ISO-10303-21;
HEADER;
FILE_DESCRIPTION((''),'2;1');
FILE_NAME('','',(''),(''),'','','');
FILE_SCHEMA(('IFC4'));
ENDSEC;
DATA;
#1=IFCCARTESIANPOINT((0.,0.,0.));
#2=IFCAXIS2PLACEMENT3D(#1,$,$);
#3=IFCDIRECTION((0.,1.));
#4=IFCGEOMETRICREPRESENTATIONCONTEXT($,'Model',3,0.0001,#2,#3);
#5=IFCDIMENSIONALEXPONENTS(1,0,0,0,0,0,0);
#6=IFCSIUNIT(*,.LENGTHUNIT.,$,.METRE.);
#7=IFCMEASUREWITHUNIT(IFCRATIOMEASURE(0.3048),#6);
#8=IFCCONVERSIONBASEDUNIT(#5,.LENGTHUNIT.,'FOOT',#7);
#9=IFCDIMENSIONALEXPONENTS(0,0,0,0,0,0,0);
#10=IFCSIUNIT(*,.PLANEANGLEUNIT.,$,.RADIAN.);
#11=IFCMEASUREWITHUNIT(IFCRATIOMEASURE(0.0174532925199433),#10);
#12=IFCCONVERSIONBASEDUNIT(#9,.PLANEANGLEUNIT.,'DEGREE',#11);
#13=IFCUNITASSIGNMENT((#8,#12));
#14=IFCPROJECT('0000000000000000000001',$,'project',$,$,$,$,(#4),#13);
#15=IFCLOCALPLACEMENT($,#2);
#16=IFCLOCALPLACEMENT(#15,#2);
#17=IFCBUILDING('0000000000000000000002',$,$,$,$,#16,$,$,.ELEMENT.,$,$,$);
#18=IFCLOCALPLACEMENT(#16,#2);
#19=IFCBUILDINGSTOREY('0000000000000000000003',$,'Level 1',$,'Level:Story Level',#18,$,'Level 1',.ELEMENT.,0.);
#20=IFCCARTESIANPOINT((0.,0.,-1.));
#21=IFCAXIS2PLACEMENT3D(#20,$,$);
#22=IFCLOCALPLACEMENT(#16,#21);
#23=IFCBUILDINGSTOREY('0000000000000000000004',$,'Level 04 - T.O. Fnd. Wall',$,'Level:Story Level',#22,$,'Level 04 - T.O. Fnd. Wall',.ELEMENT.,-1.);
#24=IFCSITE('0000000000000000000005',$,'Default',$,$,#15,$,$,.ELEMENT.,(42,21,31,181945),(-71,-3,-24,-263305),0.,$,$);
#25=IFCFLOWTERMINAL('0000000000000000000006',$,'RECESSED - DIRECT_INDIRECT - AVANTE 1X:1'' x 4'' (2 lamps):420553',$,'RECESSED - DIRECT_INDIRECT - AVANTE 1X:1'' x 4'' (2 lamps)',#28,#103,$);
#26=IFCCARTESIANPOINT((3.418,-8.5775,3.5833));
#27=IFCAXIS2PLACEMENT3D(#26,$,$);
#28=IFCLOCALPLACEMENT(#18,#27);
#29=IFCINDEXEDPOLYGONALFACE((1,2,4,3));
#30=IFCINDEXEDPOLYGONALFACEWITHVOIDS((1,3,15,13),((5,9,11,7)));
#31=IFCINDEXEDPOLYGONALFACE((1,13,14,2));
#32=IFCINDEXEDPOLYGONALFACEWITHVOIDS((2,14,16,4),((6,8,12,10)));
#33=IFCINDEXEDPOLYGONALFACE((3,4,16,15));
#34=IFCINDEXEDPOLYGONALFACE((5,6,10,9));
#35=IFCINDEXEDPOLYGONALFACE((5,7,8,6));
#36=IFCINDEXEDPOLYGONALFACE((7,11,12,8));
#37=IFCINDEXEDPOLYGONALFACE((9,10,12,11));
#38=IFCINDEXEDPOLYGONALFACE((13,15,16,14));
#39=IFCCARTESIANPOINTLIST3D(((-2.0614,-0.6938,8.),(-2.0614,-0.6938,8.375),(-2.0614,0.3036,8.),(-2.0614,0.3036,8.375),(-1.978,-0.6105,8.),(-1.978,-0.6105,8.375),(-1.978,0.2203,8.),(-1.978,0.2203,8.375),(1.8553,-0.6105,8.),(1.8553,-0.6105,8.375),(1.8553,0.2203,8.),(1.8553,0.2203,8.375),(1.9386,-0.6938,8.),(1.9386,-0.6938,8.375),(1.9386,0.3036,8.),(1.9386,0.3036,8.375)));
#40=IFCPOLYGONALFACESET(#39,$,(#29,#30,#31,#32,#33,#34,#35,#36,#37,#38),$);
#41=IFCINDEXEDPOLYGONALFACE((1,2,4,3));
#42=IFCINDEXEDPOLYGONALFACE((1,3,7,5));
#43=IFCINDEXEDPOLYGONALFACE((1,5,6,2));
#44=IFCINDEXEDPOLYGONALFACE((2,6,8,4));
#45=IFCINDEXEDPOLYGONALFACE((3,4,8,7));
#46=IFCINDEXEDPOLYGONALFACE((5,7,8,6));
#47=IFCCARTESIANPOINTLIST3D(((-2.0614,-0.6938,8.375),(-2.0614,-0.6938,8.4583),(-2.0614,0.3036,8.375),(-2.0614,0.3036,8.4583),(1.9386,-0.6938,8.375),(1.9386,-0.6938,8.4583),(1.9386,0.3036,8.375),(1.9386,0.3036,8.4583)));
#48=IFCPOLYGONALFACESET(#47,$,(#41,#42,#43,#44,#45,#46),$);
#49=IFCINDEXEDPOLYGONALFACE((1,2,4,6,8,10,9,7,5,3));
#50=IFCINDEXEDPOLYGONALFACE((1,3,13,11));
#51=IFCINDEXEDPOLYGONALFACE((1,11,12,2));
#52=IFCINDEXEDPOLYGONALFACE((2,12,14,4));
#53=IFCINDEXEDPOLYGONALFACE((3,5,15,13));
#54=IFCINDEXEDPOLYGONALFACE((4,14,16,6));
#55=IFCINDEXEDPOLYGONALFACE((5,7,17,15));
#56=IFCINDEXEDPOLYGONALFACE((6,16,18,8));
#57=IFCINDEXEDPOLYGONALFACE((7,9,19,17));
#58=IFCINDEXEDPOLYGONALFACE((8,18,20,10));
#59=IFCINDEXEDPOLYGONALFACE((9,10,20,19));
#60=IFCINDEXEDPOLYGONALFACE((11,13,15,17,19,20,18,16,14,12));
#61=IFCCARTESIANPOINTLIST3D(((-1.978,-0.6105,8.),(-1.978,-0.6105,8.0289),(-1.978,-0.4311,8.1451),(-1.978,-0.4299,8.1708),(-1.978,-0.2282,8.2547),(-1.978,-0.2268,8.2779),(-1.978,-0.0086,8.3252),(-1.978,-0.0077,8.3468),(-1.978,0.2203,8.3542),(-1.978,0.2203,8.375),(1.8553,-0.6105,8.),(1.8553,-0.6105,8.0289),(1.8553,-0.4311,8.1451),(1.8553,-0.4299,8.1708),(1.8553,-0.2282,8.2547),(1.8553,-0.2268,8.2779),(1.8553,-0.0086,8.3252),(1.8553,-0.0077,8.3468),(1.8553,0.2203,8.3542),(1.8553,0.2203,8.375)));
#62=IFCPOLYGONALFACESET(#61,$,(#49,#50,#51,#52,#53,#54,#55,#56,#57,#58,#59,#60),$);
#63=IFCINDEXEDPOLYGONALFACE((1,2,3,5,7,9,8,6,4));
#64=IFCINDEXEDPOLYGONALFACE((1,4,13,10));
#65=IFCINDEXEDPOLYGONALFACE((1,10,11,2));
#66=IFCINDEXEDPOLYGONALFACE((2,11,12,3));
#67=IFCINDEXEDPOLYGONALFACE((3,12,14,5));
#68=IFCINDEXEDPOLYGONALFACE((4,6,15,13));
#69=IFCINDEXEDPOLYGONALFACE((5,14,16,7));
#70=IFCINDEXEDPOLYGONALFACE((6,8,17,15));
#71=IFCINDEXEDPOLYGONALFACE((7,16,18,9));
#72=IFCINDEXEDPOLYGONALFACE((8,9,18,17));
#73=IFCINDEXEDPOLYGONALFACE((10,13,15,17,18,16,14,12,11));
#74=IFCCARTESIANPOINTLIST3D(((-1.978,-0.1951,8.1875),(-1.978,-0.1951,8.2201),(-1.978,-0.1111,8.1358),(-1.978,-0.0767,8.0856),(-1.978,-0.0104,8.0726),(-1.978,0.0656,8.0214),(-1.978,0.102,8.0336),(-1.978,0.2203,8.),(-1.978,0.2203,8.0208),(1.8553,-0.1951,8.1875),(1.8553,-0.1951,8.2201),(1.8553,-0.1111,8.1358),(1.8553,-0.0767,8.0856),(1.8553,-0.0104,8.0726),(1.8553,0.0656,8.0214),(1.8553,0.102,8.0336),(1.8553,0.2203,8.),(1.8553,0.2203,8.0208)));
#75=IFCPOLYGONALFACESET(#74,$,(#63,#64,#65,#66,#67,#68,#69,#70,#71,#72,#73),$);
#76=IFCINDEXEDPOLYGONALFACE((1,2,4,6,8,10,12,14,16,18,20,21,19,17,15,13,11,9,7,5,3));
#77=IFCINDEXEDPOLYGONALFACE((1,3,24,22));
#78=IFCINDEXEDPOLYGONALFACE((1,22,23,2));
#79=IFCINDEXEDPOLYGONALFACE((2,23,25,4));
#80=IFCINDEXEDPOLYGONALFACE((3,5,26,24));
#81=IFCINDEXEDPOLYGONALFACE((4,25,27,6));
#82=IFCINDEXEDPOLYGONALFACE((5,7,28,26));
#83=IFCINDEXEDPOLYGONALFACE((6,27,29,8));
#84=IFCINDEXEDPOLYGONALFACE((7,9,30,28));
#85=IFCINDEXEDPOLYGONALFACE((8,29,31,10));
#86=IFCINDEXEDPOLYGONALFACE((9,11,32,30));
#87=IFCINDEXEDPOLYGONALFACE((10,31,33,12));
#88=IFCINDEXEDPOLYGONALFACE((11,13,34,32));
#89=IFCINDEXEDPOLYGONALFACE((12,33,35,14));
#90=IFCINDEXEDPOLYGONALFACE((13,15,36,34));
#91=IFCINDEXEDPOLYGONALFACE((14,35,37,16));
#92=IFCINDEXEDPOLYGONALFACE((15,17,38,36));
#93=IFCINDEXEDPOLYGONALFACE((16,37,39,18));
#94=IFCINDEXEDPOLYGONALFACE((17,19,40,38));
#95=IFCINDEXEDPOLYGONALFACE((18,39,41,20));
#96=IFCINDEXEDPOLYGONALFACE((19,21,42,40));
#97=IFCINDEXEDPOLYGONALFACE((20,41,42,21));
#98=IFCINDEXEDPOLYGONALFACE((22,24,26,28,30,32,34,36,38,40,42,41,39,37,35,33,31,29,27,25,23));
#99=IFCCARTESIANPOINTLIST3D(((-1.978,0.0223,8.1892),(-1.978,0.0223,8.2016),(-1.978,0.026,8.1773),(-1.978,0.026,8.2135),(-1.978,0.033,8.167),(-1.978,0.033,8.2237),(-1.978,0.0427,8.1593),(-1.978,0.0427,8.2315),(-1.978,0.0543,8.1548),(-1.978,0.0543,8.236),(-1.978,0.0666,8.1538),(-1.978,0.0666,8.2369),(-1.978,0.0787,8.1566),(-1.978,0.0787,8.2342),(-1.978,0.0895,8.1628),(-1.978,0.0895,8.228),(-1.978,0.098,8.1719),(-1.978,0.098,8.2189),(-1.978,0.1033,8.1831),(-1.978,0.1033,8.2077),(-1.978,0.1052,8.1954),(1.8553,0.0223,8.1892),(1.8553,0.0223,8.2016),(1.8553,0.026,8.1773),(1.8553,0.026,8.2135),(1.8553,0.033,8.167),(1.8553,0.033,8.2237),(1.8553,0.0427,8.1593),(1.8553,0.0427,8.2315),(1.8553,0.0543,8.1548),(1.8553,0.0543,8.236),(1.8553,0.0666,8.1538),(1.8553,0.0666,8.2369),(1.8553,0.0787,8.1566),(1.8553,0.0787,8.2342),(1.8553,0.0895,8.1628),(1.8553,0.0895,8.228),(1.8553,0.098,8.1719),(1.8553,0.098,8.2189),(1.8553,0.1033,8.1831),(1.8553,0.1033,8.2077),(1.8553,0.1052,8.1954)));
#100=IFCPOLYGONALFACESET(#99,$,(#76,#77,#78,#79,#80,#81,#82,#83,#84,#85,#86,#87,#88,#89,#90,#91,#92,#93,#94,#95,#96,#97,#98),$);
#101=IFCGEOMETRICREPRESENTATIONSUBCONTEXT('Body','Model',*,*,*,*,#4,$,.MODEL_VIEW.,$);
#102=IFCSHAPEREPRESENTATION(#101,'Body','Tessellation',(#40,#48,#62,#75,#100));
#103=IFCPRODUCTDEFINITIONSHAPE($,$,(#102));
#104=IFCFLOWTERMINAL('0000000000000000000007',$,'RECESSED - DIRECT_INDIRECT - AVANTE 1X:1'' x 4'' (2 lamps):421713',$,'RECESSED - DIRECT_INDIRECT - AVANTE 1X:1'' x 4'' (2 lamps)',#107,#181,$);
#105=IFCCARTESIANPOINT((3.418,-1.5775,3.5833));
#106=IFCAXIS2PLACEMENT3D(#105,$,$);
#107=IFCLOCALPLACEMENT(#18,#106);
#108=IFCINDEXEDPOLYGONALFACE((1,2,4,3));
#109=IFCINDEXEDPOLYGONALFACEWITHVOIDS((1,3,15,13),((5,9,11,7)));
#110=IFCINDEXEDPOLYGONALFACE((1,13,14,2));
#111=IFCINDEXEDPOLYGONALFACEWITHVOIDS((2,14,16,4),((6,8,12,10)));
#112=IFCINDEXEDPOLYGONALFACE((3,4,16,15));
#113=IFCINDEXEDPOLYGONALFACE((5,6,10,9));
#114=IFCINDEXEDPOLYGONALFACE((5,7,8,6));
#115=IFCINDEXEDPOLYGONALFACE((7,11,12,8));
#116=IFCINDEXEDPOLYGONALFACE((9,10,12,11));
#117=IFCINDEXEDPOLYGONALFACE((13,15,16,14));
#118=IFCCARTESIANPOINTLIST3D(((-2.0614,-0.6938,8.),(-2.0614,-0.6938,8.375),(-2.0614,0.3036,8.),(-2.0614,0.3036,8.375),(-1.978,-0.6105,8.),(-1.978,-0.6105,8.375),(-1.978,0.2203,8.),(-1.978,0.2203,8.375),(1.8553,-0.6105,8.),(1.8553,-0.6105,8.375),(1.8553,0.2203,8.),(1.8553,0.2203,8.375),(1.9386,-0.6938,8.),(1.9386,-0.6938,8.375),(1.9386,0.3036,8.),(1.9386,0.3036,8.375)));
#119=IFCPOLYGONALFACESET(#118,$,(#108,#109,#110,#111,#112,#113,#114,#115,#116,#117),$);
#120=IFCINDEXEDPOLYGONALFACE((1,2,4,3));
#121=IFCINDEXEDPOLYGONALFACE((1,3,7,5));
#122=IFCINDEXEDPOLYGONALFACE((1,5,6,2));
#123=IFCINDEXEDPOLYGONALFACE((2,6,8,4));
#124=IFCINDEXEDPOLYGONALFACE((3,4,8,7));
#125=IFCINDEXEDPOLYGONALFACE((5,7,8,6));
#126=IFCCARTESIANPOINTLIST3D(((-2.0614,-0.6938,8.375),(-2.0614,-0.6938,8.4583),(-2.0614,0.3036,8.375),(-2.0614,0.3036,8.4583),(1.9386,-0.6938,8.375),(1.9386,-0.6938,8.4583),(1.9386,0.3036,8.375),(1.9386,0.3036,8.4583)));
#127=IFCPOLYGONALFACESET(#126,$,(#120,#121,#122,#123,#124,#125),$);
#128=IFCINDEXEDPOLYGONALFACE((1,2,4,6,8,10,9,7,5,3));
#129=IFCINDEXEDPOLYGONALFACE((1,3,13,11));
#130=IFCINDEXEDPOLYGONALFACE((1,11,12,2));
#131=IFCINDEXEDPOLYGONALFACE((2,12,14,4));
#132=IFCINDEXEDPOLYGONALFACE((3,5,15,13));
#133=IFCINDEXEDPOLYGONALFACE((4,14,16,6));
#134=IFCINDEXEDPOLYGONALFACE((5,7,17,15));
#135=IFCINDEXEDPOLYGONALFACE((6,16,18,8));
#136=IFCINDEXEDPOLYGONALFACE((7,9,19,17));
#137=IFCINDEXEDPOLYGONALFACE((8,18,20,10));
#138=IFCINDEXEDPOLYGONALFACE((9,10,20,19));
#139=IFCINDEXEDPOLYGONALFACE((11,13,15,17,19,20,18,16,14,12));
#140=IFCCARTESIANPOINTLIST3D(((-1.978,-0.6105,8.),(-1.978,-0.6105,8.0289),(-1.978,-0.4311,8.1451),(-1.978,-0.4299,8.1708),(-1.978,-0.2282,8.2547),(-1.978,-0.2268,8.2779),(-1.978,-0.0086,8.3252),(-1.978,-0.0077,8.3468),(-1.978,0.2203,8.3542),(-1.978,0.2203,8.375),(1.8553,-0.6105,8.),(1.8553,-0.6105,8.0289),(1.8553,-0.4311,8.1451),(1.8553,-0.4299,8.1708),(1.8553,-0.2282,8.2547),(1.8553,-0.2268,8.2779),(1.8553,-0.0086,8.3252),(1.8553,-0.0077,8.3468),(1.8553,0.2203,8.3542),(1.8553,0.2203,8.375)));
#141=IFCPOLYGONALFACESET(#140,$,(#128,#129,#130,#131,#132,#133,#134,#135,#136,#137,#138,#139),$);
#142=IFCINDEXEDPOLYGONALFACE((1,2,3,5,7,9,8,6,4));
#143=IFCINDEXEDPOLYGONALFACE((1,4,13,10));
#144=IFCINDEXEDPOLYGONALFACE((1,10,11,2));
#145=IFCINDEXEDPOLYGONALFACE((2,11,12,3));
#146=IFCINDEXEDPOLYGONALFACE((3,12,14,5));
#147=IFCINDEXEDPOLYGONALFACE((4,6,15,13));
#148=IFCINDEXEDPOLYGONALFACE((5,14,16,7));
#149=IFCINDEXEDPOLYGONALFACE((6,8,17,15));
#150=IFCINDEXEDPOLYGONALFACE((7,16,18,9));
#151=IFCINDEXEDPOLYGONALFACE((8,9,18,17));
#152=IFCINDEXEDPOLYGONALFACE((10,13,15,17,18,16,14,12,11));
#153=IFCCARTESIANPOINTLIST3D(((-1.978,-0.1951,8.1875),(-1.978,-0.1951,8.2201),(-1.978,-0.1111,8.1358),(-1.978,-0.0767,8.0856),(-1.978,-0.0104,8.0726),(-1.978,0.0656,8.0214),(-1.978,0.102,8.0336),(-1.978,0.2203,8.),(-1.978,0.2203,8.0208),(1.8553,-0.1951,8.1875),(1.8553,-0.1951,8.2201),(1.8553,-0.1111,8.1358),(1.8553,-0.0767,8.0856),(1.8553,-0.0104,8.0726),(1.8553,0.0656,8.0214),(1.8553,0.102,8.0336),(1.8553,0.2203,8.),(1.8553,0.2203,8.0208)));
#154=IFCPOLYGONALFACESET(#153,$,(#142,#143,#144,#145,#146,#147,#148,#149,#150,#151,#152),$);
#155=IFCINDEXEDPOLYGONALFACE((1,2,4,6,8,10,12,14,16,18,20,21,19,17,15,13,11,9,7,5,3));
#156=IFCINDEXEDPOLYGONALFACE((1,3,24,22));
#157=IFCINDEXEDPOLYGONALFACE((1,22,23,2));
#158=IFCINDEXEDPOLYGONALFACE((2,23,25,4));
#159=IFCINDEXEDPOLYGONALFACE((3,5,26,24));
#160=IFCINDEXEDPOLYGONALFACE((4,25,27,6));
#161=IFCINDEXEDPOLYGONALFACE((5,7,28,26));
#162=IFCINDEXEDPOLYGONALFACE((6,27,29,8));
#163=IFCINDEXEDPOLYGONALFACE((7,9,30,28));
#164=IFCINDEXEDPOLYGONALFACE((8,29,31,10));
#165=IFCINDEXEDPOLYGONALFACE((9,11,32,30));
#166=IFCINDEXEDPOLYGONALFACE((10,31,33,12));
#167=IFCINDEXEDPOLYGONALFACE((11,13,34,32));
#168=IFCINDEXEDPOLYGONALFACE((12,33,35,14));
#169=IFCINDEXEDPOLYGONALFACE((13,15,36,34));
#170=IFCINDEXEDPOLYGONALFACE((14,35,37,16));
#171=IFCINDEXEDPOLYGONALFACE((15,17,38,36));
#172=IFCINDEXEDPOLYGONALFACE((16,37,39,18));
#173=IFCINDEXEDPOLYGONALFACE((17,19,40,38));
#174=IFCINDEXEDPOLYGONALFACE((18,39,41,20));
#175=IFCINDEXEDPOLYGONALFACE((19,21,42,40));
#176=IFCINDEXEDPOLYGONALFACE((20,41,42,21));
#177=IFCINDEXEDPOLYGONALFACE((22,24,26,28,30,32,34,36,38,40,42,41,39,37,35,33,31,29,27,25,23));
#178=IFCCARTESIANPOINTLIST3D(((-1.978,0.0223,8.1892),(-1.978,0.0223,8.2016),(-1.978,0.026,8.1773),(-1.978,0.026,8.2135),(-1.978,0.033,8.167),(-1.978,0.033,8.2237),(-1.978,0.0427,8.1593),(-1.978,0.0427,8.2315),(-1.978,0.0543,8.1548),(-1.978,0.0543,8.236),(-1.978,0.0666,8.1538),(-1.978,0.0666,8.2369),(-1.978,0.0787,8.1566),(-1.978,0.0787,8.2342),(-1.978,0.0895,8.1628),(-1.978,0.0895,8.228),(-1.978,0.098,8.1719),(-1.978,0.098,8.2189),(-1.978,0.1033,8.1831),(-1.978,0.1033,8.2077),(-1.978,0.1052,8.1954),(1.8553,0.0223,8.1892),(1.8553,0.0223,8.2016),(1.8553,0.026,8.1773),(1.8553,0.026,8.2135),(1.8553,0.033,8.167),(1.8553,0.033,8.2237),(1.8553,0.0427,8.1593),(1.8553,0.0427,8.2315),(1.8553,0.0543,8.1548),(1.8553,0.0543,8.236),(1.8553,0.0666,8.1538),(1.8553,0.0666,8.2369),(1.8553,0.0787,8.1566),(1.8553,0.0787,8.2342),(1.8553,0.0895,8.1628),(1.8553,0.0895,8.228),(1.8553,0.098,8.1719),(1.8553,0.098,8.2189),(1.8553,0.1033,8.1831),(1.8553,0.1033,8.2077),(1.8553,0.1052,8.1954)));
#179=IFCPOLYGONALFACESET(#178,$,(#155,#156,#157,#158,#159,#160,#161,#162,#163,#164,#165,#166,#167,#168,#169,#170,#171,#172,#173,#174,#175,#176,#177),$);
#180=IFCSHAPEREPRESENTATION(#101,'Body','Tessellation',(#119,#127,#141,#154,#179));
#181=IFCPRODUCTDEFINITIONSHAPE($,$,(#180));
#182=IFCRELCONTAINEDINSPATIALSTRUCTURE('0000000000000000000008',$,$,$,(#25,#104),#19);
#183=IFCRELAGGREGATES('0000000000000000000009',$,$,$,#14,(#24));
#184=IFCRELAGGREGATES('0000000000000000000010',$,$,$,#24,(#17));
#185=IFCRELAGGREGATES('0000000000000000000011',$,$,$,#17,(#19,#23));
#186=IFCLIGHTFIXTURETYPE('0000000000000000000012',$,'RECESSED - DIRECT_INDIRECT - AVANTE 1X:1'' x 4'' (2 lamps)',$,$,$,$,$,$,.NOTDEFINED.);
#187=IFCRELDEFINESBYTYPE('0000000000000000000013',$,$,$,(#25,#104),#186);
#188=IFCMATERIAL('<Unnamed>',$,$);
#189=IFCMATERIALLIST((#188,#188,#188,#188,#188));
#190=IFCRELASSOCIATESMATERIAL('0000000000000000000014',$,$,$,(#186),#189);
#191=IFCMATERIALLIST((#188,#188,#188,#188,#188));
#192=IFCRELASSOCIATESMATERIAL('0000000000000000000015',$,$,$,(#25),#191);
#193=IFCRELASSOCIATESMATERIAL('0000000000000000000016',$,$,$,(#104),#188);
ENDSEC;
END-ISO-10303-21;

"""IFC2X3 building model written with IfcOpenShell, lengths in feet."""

from ifc_helpers import new_model, entity, si_unit, converted_unit, direction, frame, frame_2d, origin, origin_2d_with_axis, place, context, subcontext, project, spatial, polyline, circle_curve, parameter, trimmed, segment, composite_curve, rectangle, circle, outline, extrude, source, transform, mapped, material, material_list, type_object, type_shapes, element, save


model = new_model("IFC2X3")

# Units and contexts
model_context = context("Model", 3, precision=0.0001, world=origin(), true_north=direction((0.0, 1.0)))
body_context = subcontext(model_context, "Body", "Model", "MODEL_VIEW")
ifc_project = project(units=[converted_unit("LENGTHUNIT", "FOOT", entity("IfcRatioMeasure", 0.3048), si_unit("LENGTHUNIT", "METRE"), dimensions=[1, 0, 0, 0, 0, 0, 0]), converted_unit("PLANEANGLEUNIT", "DEGREE", entity("IfcRatioMeasure", 0.0174532925199433), si_unit("PLANEANGLEUNIT", "RADIAN"), dimensions=[0, 0, 0, 0, 0, 0, 0])], contexts=[model_context])

# Site, building, storey
site_placement = place(None, origin())
site = spatial("IfcSite", under=ifc_project, at=site_placement, Name="Default", CompositionType="ELEMENT", RefLatitude=(42, 21, 31, 181945), RefLongitude=(-71, -3, -24, -263305), RefElevation=0.0)
building_placement = place(site_placement, origin())
building = spatial("IfcBuilding", under=site, at=building_placement, CompositionType="ELEMENT")
storey_1_placement = place(building_placement, origin())
storey_1 = spatial("IfcBuildingStorey", under=building, at=storey_1_placement, Name="Level 1", ObjectType="Level:Story Level", LongName="Level 1", CompositionType="ELEMENT", Elevation=0.0)

# Shared definitions
storey_2_placement = place(building_placement, frame((0.0, 0.0, -1.0)))
storey_2 = spatial("IfcBuildingStorey", under=building, at=storey_2_placement, Name="Level 04 - T.O. Fnd. Wall", ObjectType="Level:Story Level", LongName="Level 04 - T.O. Fnd. Wall", CompositionType="ELEMENT", Elevation=-1.0)

# Flow terminals
ifc_material_1 = material(Name="<Unnamed>")
ifc_material_list_1 = material_list([ifc_material_1, ifc_material_1, ifc_material_1, ifc_material_1, ifc_material_1])
ifc_material_list_2 = material_list([ifc_material_1, ifc_material_1, ifc_material_1, ifc_material_1, ifc_material_1])
light_fixture_type = type_object("IfcLightFixtureType", Name="RECESSED - DIRECT_INDIRECT - AVANTE 1X:1' x 4' (2 lamps)", PredefinedType="NOTDEFINED", material=ifc_material_list_2)
shared_shape_1 = source(origin(), body_context, "Body", "SweptSolid", [
    extrude(outline(polyline([(-2.0, -0.4987), (2.0, -0.4987), (2.0, 0.4987), (-2.0, 0.4987), (-2.0, -0.4987)]), holes=[polyline([(-1.9167, -0.4154), (-1.9167, 0.4154), (1.9167, 0.4154), (1.9167, -0.4154), (-1.9167, -0.4154)])]), frame((-0.0614, -0.1951, 8.0), z_axis=(0.0, 0.0, 1.0), x_axis=(-1.0, 0.0, 0.0)), (0.0, 0.0, 1.0), 0.375),
    extrude(rectangle(XDim=4.0, YDim=0.9974, at=origin_2d_with_axis()), frame((-0.0614, -0.1951, 8.375), z_axis=(0.0, 0.0, 1.0), x_axis=(-1.0, 0.0, 0.0)), (0.0, 0.0, 1.0), 0.0833),
    extrude(outline(composite_curve([segment(trimmed(circle_curve(frame_2d((-1.0846, 0.4571), x_axis=(-1.0, 0.0)), 1.25), [parameter(135.734122)], [parameter(178.085644)], True, "PARAMETER"), False, "CONTINUOUS"), segment(polyline([(-0.1895, -0.4154), (-0.1606, -0.4154)]), True, "CONTINUOUS"), segment(trimmed(circle_curve(frame_2d((-1.0846, 0.4571), x_axis=(-1.0, 0.0)), 1.2708), [parameter(136.642648)], [parameter(178.117038)], True, "PARAMETER"), True, "CONTINUOUS"), segment(polyline([(0.1855, 0.4154), (0.1647, 0.4154)]), True, "CONTINUOUS")], self_intersect=False)), frame((-1.978, -0.1951, 8.1895), z_axis=(-1.0, 0.0, 0.0), x_axis=(0.0, 0.0, 1.0)), (0.0, 0.0, -1.0), 3.8333),
    extrude(outline(composite_curve([segment(polyline([(0.0863, -0.2077), (0.1071, -0.2077)]), True, "CONTINUOUS"), segment(trimmed(circle_curve(frame_2d((-0.4397, -0.2045), x_axis=(1.0, 0.0)), 0.5468), [parameter(359.668292)], [parameter(48.921556)], True, "PARAMETER"), True, "CONTINUOUS"), segment(polyline([(-0.0804, 0.2077), (-0.113, 0.2077)]), True, "CONTINUOUS"), segment(trimmed(circle_curve(frame_2d((-0.4397, -0.2045), x_axis=(1.0, 0.0)), 0.526), [parameter(359.655153)], [parameter(51.59762)], True, "PARAMETER"), False, "CONTINUOUS")], self_intersect=False)), frame((-1.978, 0.0126, 8.1071), z_axis=(-1.0, 0.0, 0.0), x_axis=(0.0, 0.0, -1.0)), (0.0, 0.0, -1.0), 3.8333),
    extrude(circle(Radius=0.0417, at=origin_2d_with_axis()), frame((-1.978, 0.0635, 8.1954), z_axis=(1.0, 0.0, 0.0), x_axis=(0.0, 1.0, 0.0)), (0.0, 0.0, 1.0), 3.8333),
])
type_shapes(light_fixture_type, [shared_shape_1])
flow_terminal_1_placement = place(storey_1_placement, frame((3.418, -8.5775, 3.5833)))
element("IfcFlowTerminal", 1, at=flow_terminal_1_placement, inside=storey_1, type_object=light_fixture_type, material=ifc_material_list_1, Name="RECESSED - DIRECT_INDIRECT - AVANTE 1X:1' x 4' (2 lamps):420553", ObjectType="RECESSED - DIRECT_INDIRECT - AVANTE 1X:1' x 4' (2 lamps)", context=body_context, shape_type="MappedRepresentation", body=[
    mapped(shared_shape_1, transform((0.0, 0.0, 0.0), scale=1.0)),
])
flow_terminal_2_placement = place(storey_1_placement, frame((3.418, -1.5775, 3.5833)))
element("IfcFlowTerminal", 2, at=flow_terminal_2_placement, inside=storey_1, type_object=light_fixture_type, material=ifc_material_1, Name="RECESSED - DIRECT_INDIRECT - AVANTE 1X:1' x 4' (2 lamps):421713", ObjectType="RECESSED - DIRECT_INDIRECT - AVANTE 1X:1' x 4' (2 lamps)", context=body_context, shape_type="MappedRepresentation", body=[
    mapped(shared_shape_1, transform((0.0, 0.0, 0.0), scale=1.0)),
])

save(model, "model.ifc")
